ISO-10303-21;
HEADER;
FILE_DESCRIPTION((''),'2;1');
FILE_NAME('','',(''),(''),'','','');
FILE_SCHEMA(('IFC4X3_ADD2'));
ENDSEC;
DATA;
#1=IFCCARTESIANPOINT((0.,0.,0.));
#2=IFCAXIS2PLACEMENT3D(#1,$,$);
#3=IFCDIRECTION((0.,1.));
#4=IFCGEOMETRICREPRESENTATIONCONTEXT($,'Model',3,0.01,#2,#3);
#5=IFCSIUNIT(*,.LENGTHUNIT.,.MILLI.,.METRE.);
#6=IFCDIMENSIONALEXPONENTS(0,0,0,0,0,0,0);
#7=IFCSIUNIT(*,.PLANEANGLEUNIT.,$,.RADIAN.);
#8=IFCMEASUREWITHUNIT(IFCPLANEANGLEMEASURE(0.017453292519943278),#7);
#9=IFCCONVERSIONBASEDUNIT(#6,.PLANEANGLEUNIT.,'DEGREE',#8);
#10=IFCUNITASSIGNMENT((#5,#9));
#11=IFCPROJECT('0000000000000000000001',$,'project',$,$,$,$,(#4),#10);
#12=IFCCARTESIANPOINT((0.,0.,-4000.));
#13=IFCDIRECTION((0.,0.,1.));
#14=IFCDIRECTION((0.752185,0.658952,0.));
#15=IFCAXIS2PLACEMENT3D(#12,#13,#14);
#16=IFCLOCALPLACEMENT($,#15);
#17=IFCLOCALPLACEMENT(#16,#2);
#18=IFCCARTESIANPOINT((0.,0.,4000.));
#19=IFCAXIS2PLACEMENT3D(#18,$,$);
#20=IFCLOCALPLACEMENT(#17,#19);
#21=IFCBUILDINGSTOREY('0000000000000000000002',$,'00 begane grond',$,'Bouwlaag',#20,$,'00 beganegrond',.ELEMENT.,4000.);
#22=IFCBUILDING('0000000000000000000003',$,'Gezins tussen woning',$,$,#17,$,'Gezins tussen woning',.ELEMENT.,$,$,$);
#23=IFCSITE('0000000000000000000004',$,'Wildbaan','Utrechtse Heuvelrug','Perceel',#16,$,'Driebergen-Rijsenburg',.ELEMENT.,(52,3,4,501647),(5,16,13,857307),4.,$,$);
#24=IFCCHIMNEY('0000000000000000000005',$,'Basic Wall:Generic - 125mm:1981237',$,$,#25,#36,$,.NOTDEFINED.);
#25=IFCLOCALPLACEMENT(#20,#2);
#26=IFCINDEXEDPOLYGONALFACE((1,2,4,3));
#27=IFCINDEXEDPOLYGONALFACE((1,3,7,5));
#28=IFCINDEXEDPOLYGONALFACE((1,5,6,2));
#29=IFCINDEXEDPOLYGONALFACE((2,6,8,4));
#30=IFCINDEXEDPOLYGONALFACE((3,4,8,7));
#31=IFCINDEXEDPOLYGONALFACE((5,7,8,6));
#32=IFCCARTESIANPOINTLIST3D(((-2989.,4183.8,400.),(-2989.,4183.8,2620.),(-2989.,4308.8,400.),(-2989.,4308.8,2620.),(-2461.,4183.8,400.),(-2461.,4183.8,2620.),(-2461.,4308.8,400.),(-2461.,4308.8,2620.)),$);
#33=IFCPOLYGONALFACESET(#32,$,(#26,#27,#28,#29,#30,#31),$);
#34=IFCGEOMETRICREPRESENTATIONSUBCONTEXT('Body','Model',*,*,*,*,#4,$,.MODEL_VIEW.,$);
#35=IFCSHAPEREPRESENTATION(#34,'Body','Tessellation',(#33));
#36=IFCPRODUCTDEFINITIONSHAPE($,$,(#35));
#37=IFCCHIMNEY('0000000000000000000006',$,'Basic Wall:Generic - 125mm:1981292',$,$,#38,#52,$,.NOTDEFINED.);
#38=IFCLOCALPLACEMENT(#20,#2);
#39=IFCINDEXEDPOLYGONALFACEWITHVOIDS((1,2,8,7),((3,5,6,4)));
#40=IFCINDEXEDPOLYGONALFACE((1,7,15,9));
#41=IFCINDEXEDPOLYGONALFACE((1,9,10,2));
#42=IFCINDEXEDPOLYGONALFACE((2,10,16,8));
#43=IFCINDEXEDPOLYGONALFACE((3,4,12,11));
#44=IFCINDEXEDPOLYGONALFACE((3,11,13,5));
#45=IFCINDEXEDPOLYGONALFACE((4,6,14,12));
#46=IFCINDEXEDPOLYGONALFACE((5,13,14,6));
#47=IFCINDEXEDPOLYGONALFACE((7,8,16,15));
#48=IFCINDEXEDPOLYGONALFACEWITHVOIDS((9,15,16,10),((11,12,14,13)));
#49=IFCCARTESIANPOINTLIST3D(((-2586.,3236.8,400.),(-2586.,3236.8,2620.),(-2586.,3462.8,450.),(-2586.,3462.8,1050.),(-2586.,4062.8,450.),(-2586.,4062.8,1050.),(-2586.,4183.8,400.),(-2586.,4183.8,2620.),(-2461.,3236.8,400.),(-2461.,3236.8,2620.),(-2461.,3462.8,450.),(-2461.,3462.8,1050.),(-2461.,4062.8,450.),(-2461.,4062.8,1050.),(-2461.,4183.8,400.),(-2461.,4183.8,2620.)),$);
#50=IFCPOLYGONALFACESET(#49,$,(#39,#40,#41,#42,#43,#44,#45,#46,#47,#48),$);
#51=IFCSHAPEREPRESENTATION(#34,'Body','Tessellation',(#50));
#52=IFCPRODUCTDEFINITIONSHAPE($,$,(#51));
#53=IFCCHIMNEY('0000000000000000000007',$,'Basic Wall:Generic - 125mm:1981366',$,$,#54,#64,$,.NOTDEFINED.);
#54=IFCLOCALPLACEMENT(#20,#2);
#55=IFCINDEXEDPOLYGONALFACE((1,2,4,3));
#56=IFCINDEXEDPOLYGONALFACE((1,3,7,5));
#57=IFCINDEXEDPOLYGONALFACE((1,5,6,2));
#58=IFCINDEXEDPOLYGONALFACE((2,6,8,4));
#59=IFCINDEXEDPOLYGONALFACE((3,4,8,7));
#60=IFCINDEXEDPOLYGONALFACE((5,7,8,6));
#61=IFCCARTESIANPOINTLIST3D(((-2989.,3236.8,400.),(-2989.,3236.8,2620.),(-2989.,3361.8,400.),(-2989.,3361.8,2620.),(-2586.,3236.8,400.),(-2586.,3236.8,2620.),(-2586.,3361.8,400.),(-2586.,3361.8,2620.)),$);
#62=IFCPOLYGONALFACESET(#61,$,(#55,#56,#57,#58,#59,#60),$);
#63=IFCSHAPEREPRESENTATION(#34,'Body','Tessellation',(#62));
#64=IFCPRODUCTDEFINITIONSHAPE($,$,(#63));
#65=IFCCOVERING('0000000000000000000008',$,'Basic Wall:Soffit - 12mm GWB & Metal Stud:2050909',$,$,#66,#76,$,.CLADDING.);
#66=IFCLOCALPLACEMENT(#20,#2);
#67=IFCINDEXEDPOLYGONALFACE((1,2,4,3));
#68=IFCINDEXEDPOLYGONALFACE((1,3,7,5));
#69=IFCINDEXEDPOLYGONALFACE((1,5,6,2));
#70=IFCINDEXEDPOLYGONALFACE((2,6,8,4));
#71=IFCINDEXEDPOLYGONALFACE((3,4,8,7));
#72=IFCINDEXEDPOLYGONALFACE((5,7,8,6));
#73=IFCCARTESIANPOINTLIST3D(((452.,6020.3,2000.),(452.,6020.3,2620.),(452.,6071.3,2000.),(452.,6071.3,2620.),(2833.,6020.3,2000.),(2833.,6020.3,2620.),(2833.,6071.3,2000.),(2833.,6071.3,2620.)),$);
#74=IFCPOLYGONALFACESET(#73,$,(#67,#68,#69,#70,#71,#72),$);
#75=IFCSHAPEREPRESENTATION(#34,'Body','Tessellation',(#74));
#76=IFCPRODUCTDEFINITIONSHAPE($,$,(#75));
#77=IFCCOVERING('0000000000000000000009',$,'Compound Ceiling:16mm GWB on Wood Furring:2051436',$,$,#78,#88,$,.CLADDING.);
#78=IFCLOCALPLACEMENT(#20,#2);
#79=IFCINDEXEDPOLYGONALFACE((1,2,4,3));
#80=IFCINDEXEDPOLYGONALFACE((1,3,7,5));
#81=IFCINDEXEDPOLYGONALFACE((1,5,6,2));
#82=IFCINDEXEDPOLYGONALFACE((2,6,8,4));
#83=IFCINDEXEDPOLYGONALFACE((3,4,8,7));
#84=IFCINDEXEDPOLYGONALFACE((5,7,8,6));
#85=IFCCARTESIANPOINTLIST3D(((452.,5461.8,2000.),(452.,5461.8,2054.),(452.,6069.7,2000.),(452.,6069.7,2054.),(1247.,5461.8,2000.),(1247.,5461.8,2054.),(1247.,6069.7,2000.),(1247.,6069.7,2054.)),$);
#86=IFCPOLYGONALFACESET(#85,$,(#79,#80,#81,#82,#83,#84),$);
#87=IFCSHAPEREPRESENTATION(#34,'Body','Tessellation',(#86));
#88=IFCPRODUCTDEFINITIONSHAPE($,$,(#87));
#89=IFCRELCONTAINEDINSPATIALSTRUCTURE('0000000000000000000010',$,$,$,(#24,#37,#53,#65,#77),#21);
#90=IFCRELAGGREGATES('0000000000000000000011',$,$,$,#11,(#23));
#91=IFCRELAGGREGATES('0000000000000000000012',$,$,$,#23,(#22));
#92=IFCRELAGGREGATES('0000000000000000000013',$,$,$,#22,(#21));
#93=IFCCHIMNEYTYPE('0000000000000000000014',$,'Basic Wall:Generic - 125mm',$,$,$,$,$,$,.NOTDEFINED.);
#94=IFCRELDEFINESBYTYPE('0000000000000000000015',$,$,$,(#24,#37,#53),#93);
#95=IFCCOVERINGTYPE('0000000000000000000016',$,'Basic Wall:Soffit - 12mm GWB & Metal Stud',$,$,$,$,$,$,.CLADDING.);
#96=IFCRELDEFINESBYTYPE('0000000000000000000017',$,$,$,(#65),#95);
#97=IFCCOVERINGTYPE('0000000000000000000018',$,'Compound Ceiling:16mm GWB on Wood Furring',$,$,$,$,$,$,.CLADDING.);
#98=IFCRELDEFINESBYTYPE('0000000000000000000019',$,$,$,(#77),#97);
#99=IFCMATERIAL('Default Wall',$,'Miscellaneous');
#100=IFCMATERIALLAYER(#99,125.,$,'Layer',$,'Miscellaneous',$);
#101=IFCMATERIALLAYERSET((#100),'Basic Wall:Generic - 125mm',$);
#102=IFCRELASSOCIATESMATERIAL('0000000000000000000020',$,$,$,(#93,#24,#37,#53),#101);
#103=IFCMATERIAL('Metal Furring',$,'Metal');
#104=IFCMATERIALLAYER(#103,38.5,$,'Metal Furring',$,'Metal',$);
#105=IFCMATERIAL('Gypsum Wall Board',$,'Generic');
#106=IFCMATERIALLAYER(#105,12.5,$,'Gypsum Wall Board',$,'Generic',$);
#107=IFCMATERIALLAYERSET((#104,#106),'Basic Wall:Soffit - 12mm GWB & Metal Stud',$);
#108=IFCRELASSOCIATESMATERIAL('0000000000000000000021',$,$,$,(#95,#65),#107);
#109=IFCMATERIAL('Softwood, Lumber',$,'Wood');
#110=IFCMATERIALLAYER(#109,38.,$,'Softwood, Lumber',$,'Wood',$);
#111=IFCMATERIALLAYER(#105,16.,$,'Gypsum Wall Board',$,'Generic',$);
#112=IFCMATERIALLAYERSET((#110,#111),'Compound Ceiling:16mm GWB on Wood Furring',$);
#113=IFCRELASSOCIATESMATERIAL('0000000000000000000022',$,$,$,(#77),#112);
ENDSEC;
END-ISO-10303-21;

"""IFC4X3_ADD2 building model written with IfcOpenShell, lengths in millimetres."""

from ifc_helpers import new_model, entity, si_unit, converted_unit, direction, frame, frame_2d, origin, origin_2d_with_axis, place, context, subcontext, project, spatial, rectangle, extrude, material, layer, layer_set, layer_usage, type_object, element, save


model = new_model("IFC4X3_ADD2")

# Units and contexts
model_context = context("Model", 3, precision=0.01, world=origin(), true_north=direction((0.0, 1.0)))
body_context = subcontext(model_context, "Body", "Model", "MODEL_VIEW")
ifc_project = project(units=[si_unit("LENGTHUNIT", "METRE", prefix="MILLI"), converted_unit("PLANEANGLEUNIT", "DEGREE", entity("IfcPlaneAngleMeasure", 0.017453292519943278), si_unit("PLANEANGLEUNIT", "RADIAN"), dimensions=[0, 0, 0, 0, 0, 0, 0])], contexts=[model_context])

# Site, building, storey
site_placement = place(None, frame((0.0, 0.0, -4000.0), z_axis=(0.0, 0.0, 1.0), x_axis=(0.752185, 0.658952, 0.0)))
site = spatial("IfcSite", under=ifc_project, at=site_placement, Name="Wildbaan", Description="Utrechtse Heuvelrug", ObjectType="Perceel", LongName="Driebergen-Rijsenburg", CompositionType="ELEMENT", RefLatitude=(52, 3, 4, 501647), RefLongitude=(5, 16, 13, 857307), RefElevation=4.0)
building_placement = place(site_placement, origin())
building = spatial("IfcBuilding", under=site, at=building_placement, Name="Gezins tussen woning", LongName="Gezins tussen woning", CompositionType="ELEMENT")
storey_placement = place(building_placement, frame((0.0, 0.0, 4000.0)))
storey = spatial("IfcBuildingStorey", under=building, at=storey_placement, Name="00 begane grond", ObjectType="Bouwlaag", LongName="00 beganegrond", CompositionType="ELEMENT", Elevation=4000.0)

# Shared definitions
ifc_material_1 = material(Name="Gypsum Wall Board", Category="Generic")
ifc_material_2 = material(Name="Softwood, Lumber", Category="Wood")

# Shared definitions
ifc_material_3 = material(Name="Default Wall", Category="Miscellaneous")

# Chimney
ifc_layer_1 = layer(ifc_material_3, 125.0, Name="Layer", Category="Miscellaneous")
ifc_layer_set_1 = layer_set([ifc_layer_1], Name="Basic Wall:Generic - 125mm")
ifc_layer_usage_1 = layer_usage(ifc_layer_set_1, "AXIS2", "NEGATIVE", 62.5)
chimney_type = type_object("IfcChimneyType", Name="Basic Wall:Generic - 125mm", PredefinedType="NOTDEFINED", material=ifc_layer_set_1)
chimney_1_placement = place(storey_placement, frame((-2989.0, 4246.3, 400.0)))
element("IfcChimney", 1, at=chimney_1_placement, inside=storey, type_object=chimney_type, material=ifc_layer_usage_1, Name="Basic Wall:Generic - 125mm:1981237", PredefinedType="NOTDEFINED", context=body_context, shape_type="SweptSolid", body=[
    extrude(rectangle(XDim=528.0, YDim=125.0, at=frame_2d((264.0, 0.0), x_axis=(-1.0, 0.0))), origin(), (0.0, 0.0, 1.0), 2220.0),
])

# Chimney, opening
ifc_layer_usage_2 = layer_usage(ifc_layer_set_1, "AXIS2", "NEGATIVE", 62.5)
chimney_2_placement = place(storey_placement, frame((-2523.5, 4183.8, 400.0), z_axis=(0.0, 0.0, 1.0), x_axis=(0.0, -1.0, 0.0)))
chimney_2 = element("IfcChimney", 2, at=chimney_2_placement, inside=storey, type_object=chimney_type, material=ifc_layer_usage_2, Name="Basic Wall:Generic - 125mm:1981292", PredefinedType="NOTDEFINED", context=body_context, shape_type="SweptSolid", body=[
    extrude(rectangle(XDim=947.0, YDim=125.0, at=frame_2d((473.5, 0.0), x_axis=(-1.0, 0.0))), origin(), (0.0, 0.0, 1.0), 2220.0),
])
opening_1_placement = place(chimney_2_placement, frame((4183.8, 2523.5, 50.0), z_axis=(0.0, 0.0, 1.0), x_axis=(0.0, 1.0, 0.0)))
element("IfcOpeningElement", 3, at=opening_1_placement, cuts=chimney_2, PredefinedType="OPENING", context=body_context, shape_type="SweptSolid", body=[
    extrude(rectangle(XDim=600.0, YDim=600.0, at=origin_2d_with_axis()), frame((-2586.0, 3762.8, 300.0), z_axis=(1.0, 0.0, 0.0), x_axis=(0.0, 0.0, -1.0)), (0.0, 0.0, 1.0), 125.0),
])

# Chimney
ifc_layer_usage_3 = layer_usage(ifc_layer_set_1, "AXIS2", "NEGATIVE", 62.5)
chimney_3_placement = place(storey_placement, frame((-2586.0, 3299.3, 400.0), z_axis=(0.0, 0.0, 1.0), x_axis=(-1.0, 0.0, 0.0)))
element("IfcChimney", 4, at=chimney_3_placement, inside=storey, type_object=chimney_type, material=ifc_layer_usage_3, Name="Basic Wall:Generic - 125mm:1981366", PredefinedType="NOTDEFINED", context=body_context, shape_type="SweptSolid", body=[
    extrude(rectangle(XDim=403.0, YDim=125.0, at=frame_2d((201.5, 0.0), x_axis=(-1.0, 0.0))), origin(), (0.0, 0.0, 1.0), 2220.0),
])

# Coverings
ifc_material_4 = material(Name="Metal Furring", Category="Metal")
ifc_layer_2 = layer(ifc_material_4, 38.5, Name="Metal Furring", Category="Metal")
ifc_layer_3 = layer(ifc_material_1, 12.5, Name="Gypsum Wall Board", Category="Generic")
ifc_layer_set_2 = layer_set([ifc_layer_2, ifc_layer_3], Name="Basic Wall:Soffit - 12mm GWB & Metal Stud")
ifc_layer_usage_4 = layer_usage(ifc_layer_set_2, "AXIS2", "NEGATIVE", 25.5)
covering_type_1 = type_object("IfcCoveringType", Name="Basic Wall:Soffit - 12mm GWB & Metal Stud", PredefinedType="CLADDING", material=ifc_layer_set_2)
covering_1_placement = place(storey_placement, frame((452.0, 6045.8, 2000.0)))
element("IfcCovering", 5, at=covering_1_placement, inside=storey, type_object=covering_type_1, material=ifc_layer_usage_4, Name="Basic Wall:Soffit - 12mm GWB & Metal Stud:2050909", PredefinedType="CLADDING", context=body_context, shape_type="SweptSolid", body=[
    extrude(rectangle(XDim=2381.0, YDim=51.0, at=frame_2d((1190.5, 0.0), x_axis=(-1.0, 0.0))), origin(), (0.0, 0.0, 1.0), 620.0),
])
ifc_layer_4 = layer(ifc_material_2, 38.0, Name="Softwood, Lumber", Category="Wood")
ifc_layer_5 = layer(ifc_material_1, 16.0, Name="Gypsum Wall Board", Category="Generic")
ifc_layer_set_3 = layer_set([ifc_layer_4, ifc_layer_5], Name="Compound Ceiling:16mm GWB on Wood Furring")
ifc_layer_usage_5 = layer_usage(ifc_layer_set_3, "AXIS3", "NEGATIVE", 0.0)
covering_type_2 = type_object("IfcCoveringType", Name="Compound Ceiling:16mm GWB on Wood Furring", PredefinedType="CLADDING")
covering_2_placement = place(storey_placement, frame((452.0, 5461.8, 2000.0)))
element("IfcCovering", 6, at=covering_2_placement, inside=storey, type_object=covering_type_2, material=ifc_layer_usage_5, Name="Compound Ceiling:16mm GWB on Wood Furring:2051436", PredefinedType="CLADDING", context=body_context, shape_type="SweptSolid", body=[
    extrude(rectangle(XDim=795.0, YDim=607.9, at=frame_2d((0.0, 0.0), x_axis=(1.0, 0.0))), frame((397.5, 304.0, 0.0)), (0.0, 0.0, 1.0), 54.0),
])

save(model, "model.ifc")
